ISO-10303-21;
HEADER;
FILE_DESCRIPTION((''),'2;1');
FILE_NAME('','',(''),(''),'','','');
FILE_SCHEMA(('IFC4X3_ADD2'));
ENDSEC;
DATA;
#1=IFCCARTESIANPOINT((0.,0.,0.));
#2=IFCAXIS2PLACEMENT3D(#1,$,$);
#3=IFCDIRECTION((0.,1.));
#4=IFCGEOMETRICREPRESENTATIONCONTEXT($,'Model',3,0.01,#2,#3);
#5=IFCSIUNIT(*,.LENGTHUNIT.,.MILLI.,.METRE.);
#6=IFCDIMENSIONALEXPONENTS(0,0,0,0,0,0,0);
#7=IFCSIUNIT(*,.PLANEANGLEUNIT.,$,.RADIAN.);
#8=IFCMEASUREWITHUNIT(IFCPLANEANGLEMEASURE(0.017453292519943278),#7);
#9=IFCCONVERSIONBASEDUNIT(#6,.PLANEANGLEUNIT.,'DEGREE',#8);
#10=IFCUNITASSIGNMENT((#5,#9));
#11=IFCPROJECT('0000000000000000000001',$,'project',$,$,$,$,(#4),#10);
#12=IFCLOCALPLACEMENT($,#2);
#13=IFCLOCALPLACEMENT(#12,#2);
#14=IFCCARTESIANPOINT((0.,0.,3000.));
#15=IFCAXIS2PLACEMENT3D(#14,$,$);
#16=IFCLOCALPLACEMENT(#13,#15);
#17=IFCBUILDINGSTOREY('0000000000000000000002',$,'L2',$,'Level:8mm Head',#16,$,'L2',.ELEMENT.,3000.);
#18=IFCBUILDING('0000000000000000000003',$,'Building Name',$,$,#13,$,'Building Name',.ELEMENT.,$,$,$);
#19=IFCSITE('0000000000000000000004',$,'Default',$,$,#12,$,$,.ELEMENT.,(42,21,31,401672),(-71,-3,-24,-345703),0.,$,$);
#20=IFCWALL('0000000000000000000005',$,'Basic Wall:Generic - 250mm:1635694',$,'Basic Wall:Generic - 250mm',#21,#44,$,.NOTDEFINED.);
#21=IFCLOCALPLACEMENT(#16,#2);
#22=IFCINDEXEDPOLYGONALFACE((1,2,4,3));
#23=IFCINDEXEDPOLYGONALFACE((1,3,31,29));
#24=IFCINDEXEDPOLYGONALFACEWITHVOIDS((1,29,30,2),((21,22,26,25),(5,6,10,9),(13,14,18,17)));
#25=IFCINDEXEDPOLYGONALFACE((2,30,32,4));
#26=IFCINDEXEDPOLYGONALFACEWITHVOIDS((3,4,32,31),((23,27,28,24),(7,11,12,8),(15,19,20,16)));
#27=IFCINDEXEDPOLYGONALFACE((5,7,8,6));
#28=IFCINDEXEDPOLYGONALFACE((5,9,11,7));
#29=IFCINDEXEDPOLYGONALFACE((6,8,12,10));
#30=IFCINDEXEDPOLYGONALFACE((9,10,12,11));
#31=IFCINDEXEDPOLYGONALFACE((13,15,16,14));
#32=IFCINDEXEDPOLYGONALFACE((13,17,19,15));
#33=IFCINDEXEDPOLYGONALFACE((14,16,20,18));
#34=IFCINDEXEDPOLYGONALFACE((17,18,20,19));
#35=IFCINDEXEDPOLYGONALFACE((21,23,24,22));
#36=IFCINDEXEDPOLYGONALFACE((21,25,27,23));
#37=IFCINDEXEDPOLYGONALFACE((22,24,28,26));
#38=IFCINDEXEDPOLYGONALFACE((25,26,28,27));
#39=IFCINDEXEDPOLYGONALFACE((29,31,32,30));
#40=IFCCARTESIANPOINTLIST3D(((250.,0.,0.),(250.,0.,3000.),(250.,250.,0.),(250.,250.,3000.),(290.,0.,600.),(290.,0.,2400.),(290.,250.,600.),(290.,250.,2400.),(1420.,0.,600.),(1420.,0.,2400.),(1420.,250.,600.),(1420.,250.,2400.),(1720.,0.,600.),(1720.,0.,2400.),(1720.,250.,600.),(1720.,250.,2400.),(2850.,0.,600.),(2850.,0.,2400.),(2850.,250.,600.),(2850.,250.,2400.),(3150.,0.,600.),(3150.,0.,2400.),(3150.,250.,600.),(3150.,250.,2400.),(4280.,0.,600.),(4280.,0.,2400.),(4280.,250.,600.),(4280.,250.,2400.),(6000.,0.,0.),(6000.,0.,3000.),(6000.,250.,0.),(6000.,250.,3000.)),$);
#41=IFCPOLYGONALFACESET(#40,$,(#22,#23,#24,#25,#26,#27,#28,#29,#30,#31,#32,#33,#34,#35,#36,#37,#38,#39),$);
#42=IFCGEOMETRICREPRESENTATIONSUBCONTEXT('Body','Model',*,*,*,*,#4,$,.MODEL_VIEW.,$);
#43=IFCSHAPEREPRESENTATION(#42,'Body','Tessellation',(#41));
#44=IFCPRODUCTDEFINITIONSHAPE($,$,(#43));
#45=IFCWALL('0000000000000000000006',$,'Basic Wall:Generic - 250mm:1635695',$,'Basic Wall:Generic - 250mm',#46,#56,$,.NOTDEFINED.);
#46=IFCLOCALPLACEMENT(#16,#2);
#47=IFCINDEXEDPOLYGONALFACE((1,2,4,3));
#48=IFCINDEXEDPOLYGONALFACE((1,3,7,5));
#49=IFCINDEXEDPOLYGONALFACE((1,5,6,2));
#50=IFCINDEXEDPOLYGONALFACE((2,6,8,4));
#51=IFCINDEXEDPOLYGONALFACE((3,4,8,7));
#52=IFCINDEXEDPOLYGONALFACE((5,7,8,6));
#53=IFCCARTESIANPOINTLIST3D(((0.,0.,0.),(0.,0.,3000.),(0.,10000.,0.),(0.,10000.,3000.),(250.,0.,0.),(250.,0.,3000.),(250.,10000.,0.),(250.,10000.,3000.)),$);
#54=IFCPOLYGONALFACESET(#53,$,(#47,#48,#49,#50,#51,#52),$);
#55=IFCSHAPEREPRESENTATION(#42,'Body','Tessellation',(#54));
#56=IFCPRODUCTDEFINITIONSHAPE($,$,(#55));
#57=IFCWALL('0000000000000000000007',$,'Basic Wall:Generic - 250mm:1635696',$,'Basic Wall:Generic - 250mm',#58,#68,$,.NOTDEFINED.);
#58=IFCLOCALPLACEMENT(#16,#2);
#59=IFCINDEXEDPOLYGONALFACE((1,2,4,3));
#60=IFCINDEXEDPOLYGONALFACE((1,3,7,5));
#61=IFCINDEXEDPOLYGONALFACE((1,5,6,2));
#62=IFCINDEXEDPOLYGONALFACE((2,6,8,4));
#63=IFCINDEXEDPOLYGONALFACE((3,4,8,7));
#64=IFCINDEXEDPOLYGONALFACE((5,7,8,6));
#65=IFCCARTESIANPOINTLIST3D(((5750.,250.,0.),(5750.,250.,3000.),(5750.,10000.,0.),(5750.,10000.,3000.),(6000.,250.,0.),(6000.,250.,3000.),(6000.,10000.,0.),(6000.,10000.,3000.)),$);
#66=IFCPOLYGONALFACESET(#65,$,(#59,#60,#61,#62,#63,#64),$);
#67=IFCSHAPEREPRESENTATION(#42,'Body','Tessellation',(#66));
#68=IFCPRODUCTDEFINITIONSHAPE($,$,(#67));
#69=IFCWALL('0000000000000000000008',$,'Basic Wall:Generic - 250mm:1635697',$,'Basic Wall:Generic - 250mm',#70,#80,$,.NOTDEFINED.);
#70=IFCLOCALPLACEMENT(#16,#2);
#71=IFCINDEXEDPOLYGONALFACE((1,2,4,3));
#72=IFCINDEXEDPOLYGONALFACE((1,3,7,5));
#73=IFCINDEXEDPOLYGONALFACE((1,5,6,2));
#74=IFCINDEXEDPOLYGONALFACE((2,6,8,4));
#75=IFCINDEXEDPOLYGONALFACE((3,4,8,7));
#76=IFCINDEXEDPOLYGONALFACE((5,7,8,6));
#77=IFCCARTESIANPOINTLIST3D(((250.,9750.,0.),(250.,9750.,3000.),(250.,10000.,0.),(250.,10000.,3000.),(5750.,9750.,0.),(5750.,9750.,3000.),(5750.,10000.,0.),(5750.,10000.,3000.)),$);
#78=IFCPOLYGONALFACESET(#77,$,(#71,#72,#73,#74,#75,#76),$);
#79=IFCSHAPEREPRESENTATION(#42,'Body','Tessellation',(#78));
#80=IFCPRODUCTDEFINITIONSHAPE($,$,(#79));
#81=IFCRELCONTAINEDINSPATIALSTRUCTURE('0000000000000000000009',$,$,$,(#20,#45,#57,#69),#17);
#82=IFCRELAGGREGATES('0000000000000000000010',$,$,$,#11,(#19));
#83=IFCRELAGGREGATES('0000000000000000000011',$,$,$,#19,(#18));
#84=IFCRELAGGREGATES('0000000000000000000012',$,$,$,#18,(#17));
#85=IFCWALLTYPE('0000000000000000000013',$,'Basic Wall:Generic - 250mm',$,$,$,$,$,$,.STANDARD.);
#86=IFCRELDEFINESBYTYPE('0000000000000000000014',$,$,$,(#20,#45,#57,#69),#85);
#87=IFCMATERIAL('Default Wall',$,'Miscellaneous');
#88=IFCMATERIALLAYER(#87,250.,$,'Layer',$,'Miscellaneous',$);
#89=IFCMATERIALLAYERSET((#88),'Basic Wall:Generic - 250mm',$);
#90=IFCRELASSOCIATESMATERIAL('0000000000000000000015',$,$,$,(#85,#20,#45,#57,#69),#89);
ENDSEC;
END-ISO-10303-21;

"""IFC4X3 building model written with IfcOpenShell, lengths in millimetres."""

from ifc_helpers import new_model, entity, si_unit, converted_unit, direction, frame, frame_2d, origin, place, context, subcontext, project, spatial, rectangle, extrude, material, layer, layer_set, type_object, element, save


model = new_model("IFC4X3")

# Units and contexts
model_context = context("Model", 3, precision=0.01, world=origin(), true_north=direction((0.0, 1.0)))
body_context = subcontext(model_context, "Body", "Model", "MODEL_VIEW")
ifc_project = project(units=[si_unit("LENGTHUNIT", "METRE", prefix="MILLI"), converted_unit("PLANEANGLEUNIT", "DEGREE", entity("IfcPlaneAngleMeasure", 0.017453292519943278), si_unit("PLANEANGLEUNIT", "RADIAN"), dimensions=[0, 0, 0, 0, 0, 0, 0])], contexts=[model_context])

# Site, building, storey
site_placement = place(None, origin())
site = spatial("IfcSite", under=ifc_project, at=site_placement, Name="Default", CompositionType="ELEMENT", RefLatitude=(42, 21, 31, 401672), RefLongitude=(-71, -3, -24, -345703), RefElevation=0.0)
building_placement = place(site_placement, origin())
building = spatial("IfcBuilding", under=site, at=building_placement, Name="Building Name", LongName="Building Name", CompositionType="ELEMENT")
storey_placement = place(building_placement, frame((0.0, 0.0, 3000.0)))
storey = spatial("IfcBuildingStorey", under=building, at=storey_placement, Name="L2", ObjectType="Level:8mm Head", LongName="L2", CompositionType="ELEMENT", Elevation=3000.0)

# Wall, openings
ifc_material = material(Name="Default Wall", Category="Miscellaneous")
ifc_layer = layer(ifc_material, 250.0, Name="Layer", Category="Miscellaneous")
ifc_layer_set = layer_set([ifc_layer], Name="Basic Wall:Generic - 250mm")
wall_type = type_object("IfcWallType", Name="Basic Wall:Generic - 250mm", PredefinedType="STANDARD", material=ifc_layer_set)
wall_1_placement = place(storey_placement, frame((250.0, 125.0, 0.0)))
wall_1 = element("IfcWall", 1, at=wall_1_placement, inside=storey, type_object=wall_type, material=ifc_layer_set, Name="Basic Wall:Generic - 250mm:1635694", ObjectType="Basic Wall:Generic - 250mm", PredefinedType="NOTDEFINED", context=body_context, shape_type="SweptSolid", body=[
    extrude(rectangle(XDim=5750.0, YDim=250.0, at=frame_2d((2875.0, 0.0), x_axis=(-1.0, 0.0))), origin(), (0.0, 0.0, 1.0), 3000.0),
])
opening_1_placement = place(wall_1_placement, frame((40.0, -125.0, 600.0)))
element("IfcOpeningElement", 2, at=opening_1_placement, cuts=wall_1, PredefinedType="OPENING", context=body_context, shape_type="SweptSolid", body=[
    extrude(rectangle(XDim=1800.0, YDim=1130.0, at=frame_2d((900.0, 565.0), x_axis=(-1.0, 0.0))), frame((0.0, 0.0, 0.0), z_axis=(0.0, 1.0, 0.0), x_axis=(0.0, 0.0, 1.0)), (0.0, 0.0, 1.0), 250.0),
])
opening_2_placement = place(wall_1_placement, frame((2900.0, -125.0, 600.0)))
element("IfcOpeningElement", 3, at=opening_2_placement, cuts=wall_1, PredefinedType="OPENING", context=body_context, shape_type="SweptSolid", body=[
    extrude(rectangle(XDim=1800.0, YDim=1130.0, at=frame_2d((900.0, 565.0), x_axis=(-1.0, 0.0))), frame((0.0, 0.0, 0.0), z_axis=(0.0, 1.0, 0.0), x_axis=(0.0, 0.0, 1.0)), (0.0, 0.0, 1.0), 250.0),
])
opening_3_placement = place(wall_1_placement, frame((1470.0, -125.0, 600.0)))
element("IfcOpeningElement", 4, at=opening_3_placement, cuts=wall_1, PredefinedType="OPENING", context=body_context, shape_type="SweptSolid", body=[
    extrude(rectangle(XDim=1800.0, YDim=1130.0, at=frame_2d((900.0, 565.0), x_axis=(-1.0, 0.0))), frame((0.0, 0.0, 0.0), z_axis=(0.0, 1.0, 0.0), x_axis=(0.0, 0.0, 1.0)), (0.0, 0.0, 1.0), 250.0),
])

# Walls
wall_2_placement = place(storey_placement, frame((125.0, 10000.0, 0.0), z_axis=(0.0, 0.0, 1.0), x_axis=(0.0, -1.0, 0.0)))
element("IfcWall", 5, at=wall_2_placement, inside=storey, type_object=wall_type, material=ifc_layer_set, Name="Basic Wall:Generic - 250mm:1635695", ObjectType="Basic Wall:Generic - 250mm", PredefinedType="NOTDEFINED", context=body_context, shape_type="SweptSolid", body=[
    extrude(rectangle(XDim=10000.0, YDim=250.0, at=frame_2d((5000.0, 0.0), x_axis=(-1.0, 0.0))), origin(), (0.0, 0.0, 1.0), 3000.0),
])
wall_3_placement = place(storey_placement, frame((5875.0, 250.0, 0.0), z_axis=(0.0, 0.0, 1.0), x_axis=(0.0, 1.0, 0.0)))
element("IfcWall", 6, at=wall_3_placement, inside=storey, type_object=wall_type, material=ifc_layer_set, Name="Basic Wall:Generic - 250mm:1635696", ObjectType="Basic Wall:Generic - 250mm", PredefinedType="NOTDEFINED", context=body_context, shape_type="SweptSolid", body=[
    extrude(rectangle(XDim=9750.0, YDim=250.0, at=frame_2d((4875.0, 0.0), x_axis=(-1.0, 0.0))), origin(), (0.0, 0.0, 1.0), 3000.0),
])
wall_4_placement = place(storey_placement, frame((5750.0, 9875.0, 0.0), z_axis=(0.0, 0.0, 1.0), x_axis=(-1.0, 0.0, 0.0)))
element("IfcWall", 7, at=wall_4_placement, inside=storey, type_object=wall_type, material=ifc_layer_set, Name="Basic Wall:Generic - 250mm:1635697", ObjectType="Basic Wall:Generic - 250mm", PredefinedType="NOTDEFINED", context=body_context, shape_type="SweptSolid", body=[
    extrude(rectangle(XDim=5500.0, YDim=250.0, at=frame_2d((2750.0, 0.0), x_axis=(-1.0, 0.0))), origin(), (0.0, 0.0, 1.0), 3000.0),
])

save(model, "model.ifc")
